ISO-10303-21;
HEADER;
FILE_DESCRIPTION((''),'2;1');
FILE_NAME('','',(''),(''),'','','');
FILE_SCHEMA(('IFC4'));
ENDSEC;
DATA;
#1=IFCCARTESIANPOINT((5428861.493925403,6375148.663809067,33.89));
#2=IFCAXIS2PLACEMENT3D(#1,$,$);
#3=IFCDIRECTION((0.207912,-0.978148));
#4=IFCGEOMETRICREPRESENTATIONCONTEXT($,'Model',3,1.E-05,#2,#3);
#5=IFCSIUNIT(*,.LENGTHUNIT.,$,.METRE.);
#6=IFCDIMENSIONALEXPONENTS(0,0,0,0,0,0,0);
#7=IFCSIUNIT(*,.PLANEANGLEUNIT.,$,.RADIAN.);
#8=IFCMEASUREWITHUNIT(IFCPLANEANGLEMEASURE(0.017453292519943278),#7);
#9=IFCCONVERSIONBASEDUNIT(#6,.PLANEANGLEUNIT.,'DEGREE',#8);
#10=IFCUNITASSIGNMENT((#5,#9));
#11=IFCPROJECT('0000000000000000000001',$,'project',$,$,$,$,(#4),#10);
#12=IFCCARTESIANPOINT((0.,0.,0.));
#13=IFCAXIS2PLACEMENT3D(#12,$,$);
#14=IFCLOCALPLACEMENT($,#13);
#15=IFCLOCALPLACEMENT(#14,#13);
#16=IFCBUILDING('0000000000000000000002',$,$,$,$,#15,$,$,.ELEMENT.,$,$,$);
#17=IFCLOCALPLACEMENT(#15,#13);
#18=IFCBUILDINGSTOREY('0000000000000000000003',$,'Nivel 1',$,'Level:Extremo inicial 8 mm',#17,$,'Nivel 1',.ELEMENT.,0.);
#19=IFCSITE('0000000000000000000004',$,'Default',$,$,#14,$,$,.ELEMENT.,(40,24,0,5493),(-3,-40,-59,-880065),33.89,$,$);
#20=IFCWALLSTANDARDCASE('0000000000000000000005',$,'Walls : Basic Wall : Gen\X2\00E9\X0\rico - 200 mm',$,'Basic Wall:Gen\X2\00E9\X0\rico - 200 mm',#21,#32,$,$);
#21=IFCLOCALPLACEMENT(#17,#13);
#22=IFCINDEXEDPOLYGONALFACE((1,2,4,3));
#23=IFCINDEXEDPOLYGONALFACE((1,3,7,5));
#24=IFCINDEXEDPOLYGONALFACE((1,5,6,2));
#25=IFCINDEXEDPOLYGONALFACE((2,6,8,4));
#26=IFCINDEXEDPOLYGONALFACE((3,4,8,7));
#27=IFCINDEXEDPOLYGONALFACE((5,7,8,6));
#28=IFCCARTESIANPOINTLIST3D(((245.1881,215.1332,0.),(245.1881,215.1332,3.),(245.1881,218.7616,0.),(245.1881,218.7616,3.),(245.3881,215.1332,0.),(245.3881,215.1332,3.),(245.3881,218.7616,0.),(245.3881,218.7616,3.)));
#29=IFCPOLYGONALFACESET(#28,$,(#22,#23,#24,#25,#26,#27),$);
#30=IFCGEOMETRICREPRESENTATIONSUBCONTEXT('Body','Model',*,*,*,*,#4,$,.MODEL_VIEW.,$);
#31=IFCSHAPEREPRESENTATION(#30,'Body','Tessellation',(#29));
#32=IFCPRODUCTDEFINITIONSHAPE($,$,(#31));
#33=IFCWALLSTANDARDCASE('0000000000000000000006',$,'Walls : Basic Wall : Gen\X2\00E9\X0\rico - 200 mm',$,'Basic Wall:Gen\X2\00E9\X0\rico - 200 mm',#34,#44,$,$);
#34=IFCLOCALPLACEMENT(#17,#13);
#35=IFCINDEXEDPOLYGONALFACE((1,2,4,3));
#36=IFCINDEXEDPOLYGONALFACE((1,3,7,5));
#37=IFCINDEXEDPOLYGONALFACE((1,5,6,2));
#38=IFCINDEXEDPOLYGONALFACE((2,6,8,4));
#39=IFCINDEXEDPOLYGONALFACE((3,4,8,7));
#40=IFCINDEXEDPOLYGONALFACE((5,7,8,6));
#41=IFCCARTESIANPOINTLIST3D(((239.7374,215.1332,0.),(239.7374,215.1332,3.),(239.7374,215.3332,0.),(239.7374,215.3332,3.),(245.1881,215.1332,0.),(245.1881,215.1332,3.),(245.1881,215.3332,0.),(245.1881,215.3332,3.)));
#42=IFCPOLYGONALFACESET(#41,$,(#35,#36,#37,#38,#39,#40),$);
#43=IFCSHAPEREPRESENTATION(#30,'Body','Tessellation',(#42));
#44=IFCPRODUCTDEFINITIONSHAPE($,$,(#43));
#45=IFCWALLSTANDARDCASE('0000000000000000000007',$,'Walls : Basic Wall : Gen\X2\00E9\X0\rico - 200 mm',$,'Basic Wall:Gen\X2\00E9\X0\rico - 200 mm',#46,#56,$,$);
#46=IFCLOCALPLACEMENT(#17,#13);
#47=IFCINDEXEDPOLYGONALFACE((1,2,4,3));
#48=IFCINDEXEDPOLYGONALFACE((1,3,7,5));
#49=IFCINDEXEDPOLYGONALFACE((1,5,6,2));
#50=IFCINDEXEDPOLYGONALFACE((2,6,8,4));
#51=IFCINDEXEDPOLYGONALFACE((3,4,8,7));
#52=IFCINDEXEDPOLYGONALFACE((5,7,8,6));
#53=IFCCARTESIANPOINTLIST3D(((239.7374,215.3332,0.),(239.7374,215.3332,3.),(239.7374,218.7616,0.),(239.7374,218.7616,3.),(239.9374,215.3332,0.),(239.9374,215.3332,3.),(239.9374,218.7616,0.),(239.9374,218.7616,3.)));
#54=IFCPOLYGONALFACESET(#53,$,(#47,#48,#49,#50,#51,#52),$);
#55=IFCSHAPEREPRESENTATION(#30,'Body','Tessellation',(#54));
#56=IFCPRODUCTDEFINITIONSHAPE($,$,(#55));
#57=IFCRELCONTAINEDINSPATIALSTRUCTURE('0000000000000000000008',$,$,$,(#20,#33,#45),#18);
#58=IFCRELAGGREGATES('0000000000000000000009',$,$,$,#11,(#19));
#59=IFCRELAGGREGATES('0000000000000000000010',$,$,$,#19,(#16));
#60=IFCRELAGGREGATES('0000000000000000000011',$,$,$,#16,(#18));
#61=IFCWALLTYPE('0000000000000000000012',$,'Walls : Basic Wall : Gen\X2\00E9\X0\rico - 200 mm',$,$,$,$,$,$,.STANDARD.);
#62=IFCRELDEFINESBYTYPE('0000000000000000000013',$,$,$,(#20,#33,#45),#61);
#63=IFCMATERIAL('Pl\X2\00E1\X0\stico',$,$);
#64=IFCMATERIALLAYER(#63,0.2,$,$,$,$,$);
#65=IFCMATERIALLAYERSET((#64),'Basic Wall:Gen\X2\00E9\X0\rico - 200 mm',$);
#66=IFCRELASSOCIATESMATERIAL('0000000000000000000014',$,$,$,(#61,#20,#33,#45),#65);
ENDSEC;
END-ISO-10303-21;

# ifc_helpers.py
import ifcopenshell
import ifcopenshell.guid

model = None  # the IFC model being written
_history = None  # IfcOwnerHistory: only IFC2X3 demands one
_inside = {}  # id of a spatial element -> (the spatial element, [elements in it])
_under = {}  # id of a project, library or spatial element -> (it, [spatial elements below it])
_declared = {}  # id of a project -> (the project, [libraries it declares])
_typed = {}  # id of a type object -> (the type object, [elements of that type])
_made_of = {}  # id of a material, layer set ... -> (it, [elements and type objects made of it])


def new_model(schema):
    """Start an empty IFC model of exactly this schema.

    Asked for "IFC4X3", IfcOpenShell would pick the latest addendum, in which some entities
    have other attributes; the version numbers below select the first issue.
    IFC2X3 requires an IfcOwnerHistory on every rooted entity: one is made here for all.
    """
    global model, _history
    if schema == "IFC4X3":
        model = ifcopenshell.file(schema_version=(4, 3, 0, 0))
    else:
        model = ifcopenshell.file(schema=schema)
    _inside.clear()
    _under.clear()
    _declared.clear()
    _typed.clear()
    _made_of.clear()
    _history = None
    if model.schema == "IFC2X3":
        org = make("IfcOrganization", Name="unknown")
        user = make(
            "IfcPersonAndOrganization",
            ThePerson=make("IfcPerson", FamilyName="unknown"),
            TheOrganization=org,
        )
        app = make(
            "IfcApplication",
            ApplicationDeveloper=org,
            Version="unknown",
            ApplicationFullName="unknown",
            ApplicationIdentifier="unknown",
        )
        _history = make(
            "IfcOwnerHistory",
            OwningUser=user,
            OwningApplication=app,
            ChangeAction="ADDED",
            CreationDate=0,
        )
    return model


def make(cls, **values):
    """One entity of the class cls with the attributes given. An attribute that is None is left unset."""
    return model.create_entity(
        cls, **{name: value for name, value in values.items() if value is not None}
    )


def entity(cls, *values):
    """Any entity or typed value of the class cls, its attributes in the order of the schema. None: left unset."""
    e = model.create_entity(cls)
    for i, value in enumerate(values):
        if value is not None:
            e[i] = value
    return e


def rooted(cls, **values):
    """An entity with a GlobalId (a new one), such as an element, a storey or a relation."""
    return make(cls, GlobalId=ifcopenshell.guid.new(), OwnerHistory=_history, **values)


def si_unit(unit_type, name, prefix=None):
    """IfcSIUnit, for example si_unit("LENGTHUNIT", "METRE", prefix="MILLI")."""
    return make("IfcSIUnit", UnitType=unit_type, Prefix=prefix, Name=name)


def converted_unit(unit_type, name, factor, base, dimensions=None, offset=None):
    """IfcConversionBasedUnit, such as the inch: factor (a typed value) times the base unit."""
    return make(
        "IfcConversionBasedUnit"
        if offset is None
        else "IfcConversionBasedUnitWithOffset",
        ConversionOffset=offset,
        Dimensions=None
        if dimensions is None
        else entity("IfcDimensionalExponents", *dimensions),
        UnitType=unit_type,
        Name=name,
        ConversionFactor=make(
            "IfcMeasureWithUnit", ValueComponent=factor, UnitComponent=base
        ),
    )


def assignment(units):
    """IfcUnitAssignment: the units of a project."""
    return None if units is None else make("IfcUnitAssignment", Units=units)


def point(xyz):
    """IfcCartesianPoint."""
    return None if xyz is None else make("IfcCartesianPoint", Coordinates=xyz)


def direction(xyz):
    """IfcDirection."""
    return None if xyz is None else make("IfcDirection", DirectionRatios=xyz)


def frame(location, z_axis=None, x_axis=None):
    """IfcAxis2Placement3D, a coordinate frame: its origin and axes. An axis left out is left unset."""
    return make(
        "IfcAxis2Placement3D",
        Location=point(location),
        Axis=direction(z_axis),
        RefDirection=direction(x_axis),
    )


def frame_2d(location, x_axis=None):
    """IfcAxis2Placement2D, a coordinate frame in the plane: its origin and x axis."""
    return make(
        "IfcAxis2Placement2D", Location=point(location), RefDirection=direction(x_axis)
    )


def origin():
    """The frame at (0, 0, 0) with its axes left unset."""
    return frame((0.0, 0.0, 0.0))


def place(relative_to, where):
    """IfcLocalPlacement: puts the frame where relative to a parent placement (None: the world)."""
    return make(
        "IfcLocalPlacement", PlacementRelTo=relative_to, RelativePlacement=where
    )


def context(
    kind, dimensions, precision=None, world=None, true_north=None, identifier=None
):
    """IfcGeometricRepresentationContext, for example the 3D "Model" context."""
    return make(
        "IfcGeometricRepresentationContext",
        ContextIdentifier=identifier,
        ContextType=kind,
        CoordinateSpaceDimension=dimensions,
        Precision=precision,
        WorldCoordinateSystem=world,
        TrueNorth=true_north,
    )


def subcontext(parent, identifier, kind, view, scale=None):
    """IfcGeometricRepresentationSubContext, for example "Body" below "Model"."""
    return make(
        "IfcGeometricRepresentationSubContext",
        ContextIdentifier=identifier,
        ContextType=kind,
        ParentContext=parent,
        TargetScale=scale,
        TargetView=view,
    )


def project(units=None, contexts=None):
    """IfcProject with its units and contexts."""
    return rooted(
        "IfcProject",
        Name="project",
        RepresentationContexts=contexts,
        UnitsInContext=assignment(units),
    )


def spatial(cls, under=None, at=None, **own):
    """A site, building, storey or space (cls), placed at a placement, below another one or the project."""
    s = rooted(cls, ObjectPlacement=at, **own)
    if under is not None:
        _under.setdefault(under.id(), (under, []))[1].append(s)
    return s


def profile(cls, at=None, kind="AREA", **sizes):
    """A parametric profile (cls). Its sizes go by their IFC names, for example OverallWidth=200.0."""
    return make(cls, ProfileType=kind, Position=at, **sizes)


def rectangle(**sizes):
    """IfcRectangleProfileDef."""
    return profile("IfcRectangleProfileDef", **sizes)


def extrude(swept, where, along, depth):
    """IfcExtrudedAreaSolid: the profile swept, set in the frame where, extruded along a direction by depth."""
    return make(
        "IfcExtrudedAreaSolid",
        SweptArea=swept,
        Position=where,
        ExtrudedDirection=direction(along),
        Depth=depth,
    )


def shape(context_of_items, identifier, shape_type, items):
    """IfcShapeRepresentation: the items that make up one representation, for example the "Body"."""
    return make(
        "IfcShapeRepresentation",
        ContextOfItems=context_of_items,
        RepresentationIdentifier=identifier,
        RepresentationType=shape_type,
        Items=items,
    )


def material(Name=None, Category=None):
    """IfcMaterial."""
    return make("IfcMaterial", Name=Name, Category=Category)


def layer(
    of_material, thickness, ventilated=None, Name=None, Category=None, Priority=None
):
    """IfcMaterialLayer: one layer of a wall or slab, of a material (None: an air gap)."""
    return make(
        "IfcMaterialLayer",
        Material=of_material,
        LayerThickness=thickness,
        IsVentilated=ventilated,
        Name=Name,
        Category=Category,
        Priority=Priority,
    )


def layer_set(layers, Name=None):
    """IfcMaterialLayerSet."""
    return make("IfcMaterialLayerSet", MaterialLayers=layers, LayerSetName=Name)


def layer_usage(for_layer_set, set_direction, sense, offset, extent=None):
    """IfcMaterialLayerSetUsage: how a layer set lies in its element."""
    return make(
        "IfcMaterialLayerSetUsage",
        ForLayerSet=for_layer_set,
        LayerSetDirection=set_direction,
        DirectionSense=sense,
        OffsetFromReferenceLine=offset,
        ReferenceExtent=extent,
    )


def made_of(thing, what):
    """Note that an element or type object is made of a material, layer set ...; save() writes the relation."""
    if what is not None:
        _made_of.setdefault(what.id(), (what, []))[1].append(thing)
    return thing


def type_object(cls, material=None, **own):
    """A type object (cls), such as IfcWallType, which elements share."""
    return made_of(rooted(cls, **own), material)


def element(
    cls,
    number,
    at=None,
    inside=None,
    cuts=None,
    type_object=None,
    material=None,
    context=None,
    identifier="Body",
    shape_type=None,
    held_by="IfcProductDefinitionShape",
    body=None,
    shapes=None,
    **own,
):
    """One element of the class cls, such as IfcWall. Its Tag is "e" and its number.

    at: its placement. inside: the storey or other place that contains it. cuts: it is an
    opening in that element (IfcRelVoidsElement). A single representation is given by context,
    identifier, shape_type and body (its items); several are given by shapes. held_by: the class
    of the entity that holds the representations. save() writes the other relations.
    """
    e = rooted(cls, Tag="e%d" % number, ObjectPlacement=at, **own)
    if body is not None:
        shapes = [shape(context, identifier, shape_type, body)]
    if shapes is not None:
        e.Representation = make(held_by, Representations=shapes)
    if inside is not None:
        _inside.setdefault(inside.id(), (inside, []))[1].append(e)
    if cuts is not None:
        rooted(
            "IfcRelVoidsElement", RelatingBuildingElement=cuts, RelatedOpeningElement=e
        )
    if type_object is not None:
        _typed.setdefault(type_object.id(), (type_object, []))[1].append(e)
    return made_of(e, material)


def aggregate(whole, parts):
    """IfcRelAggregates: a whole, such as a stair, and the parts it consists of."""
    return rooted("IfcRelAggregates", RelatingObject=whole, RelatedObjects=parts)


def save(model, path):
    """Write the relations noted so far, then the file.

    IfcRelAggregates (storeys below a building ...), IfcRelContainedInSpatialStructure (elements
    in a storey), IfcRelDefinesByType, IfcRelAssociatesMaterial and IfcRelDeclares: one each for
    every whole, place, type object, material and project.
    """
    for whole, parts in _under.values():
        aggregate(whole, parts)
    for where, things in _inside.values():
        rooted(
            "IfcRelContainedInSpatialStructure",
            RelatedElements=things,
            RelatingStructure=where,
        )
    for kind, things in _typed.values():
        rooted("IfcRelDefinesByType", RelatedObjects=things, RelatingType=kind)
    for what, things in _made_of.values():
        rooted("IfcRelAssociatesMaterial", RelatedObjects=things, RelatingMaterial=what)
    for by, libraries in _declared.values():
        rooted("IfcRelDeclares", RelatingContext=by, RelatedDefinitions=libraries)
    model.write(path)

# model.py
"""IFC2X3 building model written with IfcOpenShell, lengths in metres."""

from ifc_helpers import new_model, entity, si_unit, converted_unit, direction, frame, frame_2d, origin, place, context, subcontext, project, spatial, rectangle, extrude, material, layer, layer_set, layer_usage, type_object, element, save


model = new_model("IFC2X3")

# Units and contexts
model_context = context("Model", 3, precision=1e-05, world=frame((5428861.493925403, 6375148.663809067, 33.89)), true_north=direction((0.207912, -0.978148)))
body_context = subcontext(model_context, "Body", "Model", "MODEL_VIEW")
ifc_project = project(units=[si_unit("LENGTHUNIT", "METRE"), converted_unit("PLANEANGLEUNIT", "DEGREE", entity("IfcPlaneAngleMeasure", 0.017453292519943278), si_unit("PLANEANGLEUNIT", "RADIAN"), dimensions=[0, 0, 0, 0, 0, 0, 0])], contexts=[model_context])

# Site, building, storey
site_placement = place(None, origin())
site = spatial("IfcSite", under=ifc_project, at=site_placement, Name="Default", CompositionType="ELEMENT", RefLatitude=(40, 24, 0, 5493), RefLongitude=(-3, -40, -59, -880065), RefElevation=33.89)
building_placement = place(site_placement, origin())
building = spatial("IfcBuilding", under=site, at=building_placement, CompositionType="ELEMENT")
storey_placement = place(building_placement, origin())
storey = spatial("IfcBuildingStorey", under=building, at=storey_placement, Name="Nivel 1", ObjectType="Level:Extremo inicial 8 mm", LongName="Nivel 1", CompositionType="ELEMENT", Elevation=0.0)

# Walls
ifc_material_1 = material(Name="Plástico")
ifc_layer_1 = layer(ifc_material_1, 0.2)
ifc_layer_set_1 = layer_set([ifc_layer_1], Name="Basic Wall:Genérico - 200 mm")
wall_type = type_object("IfcWallType", Name="Walls : Basic Wall : Genérico - 200 mm", PredefinedType="STANDARD", material=ifc_layer_set_1)
ifc_layer_usage_1 = layer_usage(ifc_layer_set_1, "AXIS2", "NEGATIVE", 0.1)
wall_1_placement = place(storey_placement, frame((245.2881, 218.7616, 0.0), z_axis=(0.0, 0.0, 1.0), x_axis=(0.0, -1.0, 0.0)))
element("IfcWallStandardCase", 1, at=wall_1_placement, inside=storey, type_object=wall_type, material=ifc_layer_usage_1, Name="Walls : Basic Wall : Genérico - 200 mm", ObjectType="Basic Wall:Genérico - 200 mm", context=body_context, shape_type="SweptSolid", body=[
    extrude(rectangle(XDim=3.6285, YDim=0.2, at=frame_2d((1.8142, 0.0), x_axis=(-1.0, 0.0))), origin(), (0.0, 0.0, 1.0), 3.0),
])
ifc_layer_usage_2 = layer_usage(ifc_layer_set_1, "AXIS2", "NEGATIVE", 0.1)
wall_2_placement = place(storey_placement, frame((245.1881, 215.2332, 0.0), z_axis=(0.0, 0.0, 1.0), x_axis=(-1.0, 0.0, 0.0)))
element("IfcWallStandardCase", 2, at=wall_2_placement, inside=storey, type_object=wall_type, material=ifc_layer_usage_2, Name="Walls : Basic Wall : Genérico - 200 mm", ObjectType="Basic Wall:Genérico - 200 mm", context=body_context, shape_type="SweptSolid", body=[
    extrude(rectangle(XDim=5.4508, YDim=0.2, at=frame_2d((2.7254, 0.0), x_axis=(-1.0, 0.0))), origin(), (0.0, 0.0, 1.0), 3.0),
])
ifc_layer_usage_3 = layer_usage(ifc_layer_set_1, "AXIS2", "NEGATIVE", 0.1)
wall_3_placement = place(storey_placement, frame((239.8374, 215.3332, 0.0), z_axis=(0.0, 0.0, 1.0), x_axis=(0.0, 1.0, 0.0)))
element("IfcWallStandardCase", 3, at=wall_3_placement, inside=storey, type_object=wall_type, material=ifc_layer_usage_3, Name="Walls : Basic Wall : Genérico - 200 mm", ObjectType="Basic Wall:Genérico - 200 mm", context=body_context, shape_type="SweptSolid", body=[
    extrude(rectangle(XDim=3.4285, YDim=0.2, at=frame_2d((1.7142, 0.0), x_axis=(-1.0, 0.0))), origin(), (0.0, 0.0, 1.0), 3.0),
])

save(model, "model.ifc")
